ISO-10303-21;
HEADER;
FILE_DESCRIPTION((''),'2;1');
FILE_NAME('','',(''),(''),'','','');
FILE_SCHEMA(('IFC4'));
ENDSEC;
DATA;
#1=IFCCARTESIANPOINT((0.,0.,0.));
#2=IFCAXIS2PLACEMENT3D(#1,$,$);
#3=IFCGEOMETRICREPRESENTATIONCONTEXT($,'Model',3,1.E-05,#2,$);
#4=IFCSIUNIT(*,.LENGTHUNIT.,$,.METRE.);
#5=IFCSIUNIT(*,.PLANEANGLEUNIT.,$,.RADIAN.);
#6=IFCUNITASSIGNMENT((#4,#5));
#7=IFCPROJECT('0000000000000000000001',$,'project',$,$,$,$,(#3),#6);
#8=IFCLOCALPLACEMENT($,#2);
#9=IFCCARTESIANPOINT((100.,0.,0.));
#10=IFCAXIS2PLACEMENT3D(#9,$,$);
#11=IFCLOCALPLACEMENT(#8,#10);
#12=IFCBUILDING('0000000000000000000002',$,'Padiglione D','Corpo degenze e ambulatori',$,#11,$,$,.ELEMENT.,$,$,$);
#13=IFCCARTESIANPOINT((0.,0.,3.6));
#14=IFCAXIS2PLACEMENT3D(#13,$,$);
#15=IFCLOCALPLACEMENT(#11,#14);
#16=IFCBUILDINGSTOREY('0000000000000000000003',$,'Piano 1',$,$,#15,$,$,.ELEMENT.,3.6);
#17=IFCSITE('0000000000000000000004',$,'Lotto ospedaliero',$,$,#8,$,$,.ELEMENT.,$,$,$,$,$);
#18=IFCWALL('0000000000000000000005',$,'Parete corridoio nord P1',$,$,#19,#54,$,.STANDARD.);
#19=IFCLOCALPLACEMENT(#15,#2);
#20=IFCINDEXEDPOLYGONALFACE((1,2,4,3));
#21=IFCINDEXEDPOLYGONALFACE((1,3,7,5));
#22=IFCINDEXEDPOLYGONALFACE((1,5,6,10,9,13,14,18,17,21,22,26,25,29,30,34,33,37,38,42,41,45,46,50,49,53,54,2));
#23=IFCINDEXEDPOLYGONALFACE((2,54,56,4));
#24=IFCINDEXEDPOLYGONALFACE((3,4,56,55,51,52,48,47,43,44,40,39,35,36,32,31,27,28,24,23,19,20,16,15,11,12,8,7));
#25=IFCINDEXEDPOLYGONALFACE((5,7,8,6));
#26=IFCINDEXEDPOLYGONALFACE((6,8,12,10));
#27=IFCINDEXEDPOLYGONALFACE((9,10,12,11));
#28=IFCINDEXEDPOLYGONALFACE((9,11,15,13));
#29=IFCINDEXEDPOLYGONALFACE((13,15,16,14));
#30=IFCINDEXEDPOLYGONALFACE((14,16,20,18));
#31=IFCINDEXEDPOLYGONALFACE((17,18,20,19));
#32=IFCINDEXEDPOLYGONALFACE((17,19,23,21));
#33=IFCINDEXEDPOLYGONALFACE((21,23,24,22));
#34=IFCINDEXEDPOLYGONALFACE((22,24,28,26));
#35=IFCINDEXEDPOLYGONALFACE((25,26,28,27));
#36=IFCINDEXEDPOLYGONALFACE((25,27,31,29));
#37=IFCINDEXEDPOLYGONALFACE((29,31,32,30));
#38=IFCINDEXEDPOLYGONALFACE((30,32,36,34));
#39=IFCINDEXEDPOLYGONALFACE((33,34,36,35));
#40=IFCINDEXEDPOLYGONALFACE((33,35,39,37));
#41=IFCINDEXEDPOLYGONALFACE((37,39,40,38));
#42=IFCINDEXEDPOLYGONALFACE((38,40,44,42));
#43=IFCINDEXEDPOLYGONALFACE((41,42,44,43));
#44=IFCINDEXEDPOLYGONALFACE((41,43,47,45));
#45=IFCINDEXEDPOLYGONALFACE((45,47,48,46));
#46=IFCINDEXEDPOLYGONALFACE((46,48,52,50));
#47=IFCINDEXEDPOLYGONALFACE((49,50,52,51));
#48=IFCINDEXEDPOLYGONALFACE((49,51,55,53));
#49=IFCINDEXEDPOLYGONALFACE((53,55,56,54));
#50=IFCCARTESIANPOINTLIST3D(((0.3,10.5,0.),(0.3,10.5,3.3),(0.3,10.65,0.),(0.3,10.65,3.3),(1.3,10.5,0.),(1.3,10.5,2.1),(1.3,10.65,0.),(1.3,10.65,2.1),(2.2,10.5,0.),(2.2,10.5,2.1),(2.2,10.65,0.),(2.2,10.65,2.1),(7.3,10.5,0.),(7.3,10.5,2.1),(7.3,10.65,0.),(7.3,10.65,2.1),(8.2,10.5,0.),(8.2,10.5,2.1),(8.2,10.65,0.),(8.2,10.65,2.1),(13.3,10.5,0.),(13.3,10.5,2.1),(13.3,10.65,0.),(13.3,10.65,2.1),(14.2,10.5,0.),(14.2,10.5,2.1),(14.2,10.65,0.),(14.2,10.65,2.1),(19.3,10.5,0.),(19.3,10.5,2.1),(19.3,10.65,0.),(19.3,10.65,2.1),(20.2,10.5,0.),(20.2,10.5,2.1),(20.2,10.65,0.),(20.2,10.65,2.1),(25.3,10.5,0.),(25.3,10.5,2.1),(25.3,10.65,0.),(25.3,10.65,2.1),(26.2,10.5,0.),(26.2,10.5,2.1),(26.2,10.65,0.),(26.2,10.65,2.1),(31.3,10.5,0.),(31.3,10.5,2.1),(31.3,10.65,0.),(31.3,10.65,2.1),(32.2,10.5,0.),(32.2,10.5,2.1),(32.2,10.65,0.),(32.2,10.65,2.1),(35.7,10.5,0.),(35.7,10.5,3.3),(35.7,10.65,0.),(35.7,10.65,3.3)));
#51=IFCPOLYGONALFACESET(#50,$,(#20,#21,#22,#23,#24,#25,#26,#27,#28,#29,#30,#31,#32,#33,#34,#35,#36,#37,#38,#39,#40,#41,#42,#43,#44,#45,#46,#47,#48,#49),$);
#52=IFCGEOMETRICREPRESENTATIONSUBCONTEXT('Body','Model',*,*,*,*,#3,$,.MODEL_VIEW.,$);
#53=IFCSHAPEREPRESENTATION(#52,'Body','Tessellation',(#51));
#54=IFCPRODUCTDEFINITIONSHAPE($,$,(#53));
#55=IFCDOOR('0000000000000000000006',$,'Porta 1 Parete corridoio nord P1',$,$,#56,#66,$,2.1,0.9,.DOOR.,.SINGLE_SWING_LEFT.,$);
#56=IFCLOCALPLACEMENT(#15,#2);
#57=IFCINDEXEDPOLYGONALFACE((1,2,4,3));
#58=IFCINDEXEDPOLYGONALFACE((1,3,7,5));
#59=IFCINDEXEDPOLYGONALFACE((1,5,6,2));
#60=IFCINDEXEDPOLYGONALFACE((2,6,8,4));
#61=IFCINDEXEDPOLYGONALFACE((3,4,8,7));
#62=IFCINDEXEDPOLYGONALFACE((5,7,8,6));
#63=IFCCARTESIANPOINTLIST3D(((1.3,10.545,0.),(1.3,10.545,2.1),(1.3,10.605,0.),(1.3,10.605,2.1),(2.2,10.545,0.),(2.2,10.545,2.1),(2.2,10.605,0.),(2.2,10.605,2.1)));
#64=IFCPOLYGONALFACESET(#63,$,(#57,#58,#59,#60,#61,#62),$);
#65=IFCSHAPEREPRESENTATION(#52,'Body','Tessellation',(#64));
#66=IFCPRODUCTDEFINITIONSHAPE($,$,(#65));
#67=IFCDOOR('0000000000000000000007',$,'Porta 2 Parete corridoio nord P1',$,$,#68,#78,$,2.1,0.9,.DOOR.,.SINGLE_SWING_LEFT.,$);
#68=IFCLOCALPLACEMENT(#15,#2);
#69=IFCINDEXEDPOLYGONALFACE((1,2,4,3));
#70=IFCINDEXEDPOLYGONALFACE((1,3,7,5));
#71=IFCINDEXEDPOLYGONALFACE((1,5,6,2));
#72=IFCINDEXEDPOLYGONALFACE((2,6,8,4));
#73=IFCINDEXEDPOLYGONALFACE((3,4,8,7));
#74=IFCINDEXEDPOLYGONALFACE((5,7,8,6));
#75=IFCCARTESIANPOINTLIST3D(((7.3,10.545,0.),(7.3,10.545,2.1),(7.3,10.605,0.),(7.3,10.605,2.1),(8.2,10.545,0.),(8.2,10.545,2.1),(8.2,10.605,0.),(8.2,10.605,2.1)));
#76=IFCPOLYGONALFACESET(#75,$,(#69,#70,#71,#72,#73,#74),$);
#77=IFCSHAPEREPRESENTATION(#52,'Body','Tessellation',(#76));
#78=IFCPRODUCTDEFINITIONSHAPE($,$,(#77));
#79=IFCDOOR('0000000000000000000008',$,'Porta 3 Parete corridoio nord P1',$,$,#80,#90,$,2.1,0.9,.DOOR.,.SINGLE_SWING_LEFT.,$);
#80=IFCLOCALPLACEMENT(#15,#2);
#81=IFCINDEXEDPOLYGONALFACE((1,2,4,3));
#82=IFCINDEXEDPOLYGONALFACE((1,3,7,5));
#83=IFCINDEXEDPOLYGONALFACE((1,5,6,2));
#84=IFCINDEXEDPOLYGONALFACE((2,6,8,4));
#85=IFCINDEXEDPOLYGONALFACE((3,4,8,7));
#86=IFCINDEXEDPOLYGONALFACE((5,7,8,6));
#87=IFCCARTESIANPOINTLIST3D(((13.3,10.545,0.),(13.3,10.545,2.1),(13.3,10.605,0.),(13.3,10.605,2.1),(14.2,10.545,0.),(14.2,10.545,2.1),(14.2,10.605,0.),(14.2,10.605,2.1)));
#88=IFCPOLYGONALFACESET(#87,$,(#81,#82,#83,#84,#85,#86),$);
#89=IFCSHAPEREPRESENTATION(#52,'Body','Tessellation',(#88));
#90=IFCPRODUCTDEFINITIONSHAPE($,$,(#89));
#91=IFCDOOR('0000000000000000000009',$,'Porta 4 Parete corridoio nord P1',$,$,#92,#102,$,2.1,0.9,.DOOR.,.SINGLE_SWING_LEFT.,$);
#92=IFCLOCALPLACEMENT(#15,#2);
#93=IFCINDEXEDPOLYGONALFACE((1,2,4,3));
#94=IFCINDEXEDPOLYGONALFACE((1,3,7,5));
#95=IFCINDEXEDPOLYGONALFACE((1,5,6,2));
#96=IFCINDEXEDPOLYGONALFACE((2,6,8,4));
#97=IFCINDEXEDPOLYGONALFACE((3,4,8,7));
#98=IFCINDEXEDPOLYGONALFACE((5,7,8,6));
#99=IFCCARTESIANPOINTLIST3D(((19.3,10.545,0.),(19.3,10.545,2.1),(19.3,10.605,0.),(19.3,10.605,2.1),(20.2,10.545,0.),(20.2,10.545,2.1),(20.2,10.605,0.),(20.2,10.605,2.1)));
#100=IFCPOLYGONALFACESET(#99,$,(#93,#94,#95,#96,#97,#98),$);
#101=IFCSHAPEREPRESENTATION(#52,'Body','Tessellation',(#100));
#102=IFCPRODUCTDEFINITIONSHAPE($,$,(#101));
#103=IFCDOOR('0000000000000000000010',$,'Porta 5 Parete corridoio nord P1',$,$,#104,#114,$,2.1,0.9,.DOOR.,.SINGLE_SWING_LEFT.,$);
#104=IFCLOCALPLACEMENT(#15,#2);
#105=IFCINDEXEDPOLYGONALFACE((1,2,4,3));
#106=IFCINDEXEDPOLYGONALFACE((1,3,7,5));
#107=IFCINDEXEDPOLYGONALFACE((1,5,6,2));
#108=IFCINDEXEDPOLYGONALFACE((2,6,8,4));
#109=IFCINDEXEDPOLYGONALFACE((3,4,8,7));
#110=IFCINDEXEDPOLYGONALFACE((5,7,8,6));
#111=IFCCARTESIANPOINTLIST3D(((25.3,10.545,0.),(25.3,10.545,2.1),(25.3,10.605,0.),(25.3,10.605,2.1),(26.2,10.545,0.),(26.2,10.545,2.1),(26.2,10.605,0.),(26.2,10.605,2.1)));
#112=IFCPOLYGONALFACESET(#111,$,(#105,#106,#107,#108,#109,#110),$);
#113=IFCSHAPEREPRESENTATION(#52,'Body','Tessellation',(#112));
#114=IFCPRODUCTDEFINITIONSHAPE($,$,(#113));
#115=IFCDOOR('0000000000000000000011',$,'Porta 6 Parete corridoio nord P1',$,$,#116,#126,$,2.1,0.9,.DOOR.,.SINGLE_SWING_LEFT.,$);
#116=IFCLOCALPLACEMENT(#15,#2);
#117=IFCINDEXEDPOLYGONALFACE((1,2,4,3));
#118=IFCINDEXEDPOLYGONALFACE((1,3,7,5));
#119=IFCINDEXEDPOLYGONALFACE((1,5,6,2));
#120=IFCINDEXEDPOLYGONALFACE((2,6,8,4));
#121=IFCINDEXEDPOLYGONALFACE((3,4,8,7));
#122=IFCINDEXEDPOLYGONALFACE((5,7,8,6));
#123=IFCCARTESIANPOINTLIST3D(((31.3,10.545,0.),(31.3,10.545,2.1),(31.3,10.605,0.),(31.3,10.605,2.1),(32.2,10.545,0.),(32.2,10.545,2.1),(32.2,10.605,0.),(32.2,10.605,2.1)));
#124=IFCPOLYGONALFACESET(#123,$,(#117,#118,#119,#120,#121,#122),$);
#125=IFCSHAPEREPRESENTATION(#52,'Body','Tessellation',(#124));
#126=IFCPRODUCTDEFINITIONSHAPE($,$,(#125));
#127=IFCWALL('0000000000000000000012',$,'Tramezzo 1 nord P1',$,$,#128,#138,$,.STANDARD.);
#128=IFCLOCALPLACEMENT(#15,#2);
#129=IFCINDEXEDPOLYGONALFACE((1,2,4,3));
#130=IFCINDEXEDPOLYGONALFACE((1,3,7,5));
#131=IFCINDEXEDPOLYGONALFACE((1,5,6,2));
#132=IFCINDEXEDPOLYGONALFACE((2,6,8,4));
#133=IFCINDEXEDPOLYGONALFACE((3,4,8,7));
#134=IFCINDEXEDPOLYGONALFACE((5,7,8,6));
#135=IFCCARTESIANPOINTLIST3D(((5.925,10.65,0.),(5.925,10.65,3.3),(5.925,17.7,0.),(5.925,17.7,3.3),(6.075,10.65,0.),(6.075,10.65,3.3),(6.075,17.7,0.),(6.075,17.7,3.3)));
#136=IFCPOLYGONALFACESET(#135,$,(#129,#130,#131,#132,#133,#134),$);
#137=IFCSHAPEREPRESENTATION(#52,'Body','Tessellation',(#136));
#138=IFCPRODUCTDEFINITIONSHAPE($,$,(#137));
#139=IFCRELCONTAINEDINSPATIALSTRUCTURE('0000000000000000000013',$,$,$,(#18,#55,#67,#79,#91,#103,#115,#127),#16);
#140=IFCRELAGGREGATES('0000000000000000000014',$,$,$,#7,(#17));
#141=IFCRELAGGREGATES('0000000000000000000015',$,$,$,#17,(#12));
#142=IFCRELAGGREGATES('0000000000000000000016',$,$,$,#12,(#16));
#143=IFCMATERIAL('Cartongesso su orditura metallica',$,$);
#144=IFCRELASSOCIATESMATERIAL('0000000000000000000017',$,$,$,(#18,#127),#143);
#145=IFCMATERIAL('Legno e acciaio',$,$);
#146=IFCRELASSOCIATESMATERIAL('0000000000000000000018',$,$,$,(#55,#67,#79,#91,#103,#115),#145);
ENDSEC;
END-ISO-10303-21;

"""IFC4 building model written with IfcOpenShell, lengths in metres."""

from ifc_helpers import new_model, si_unit, frame, frame_2d, origin, place, context, subcontext, project, spatial, rectangle, extrude, material, element, fill, save


model = new_model("IFC4")

# Units and contexts
model_context = context("Model", 3, precision=1e-05, world=origin())
body_context = subcontext(model_context, "Body", "Model", "MODEL_VIEW")
ifc_project = project(units=[si_unit("LENGTHUNIT", "METRE"), si_unit("PLANEANGLEUNIT", "RADIAN")], contexts=[model_context])

# Site, building, storey
site_placement = place(None, origin())
site = spatial("IfcSite", under=ifc_project, at=site_placement, Name="Lotto ospedaliero", CompositionType="ELEMENT")
building_placement = place(site_placement, frame((100.0, 0.0, 0.0)))
building = spatial("IfcBuilding", under=site, at=building_placement, Name="Padiglione D", Description="Corpo degenze e ambulatori", CompositionType="ELEMENT")
storey_placement = place(building_placement, frame((0.0, 0.0, 3.6)))
storey = spatial("IfcBuildingStorey", under=building, at=storey_placement, Name="Piano 1", CompositionType="ELEMENT", Elevation=3.6)

# Wall, openings, doors
ifc_material_1 = material(Name="Cartongesso su orditura metallica")
ifc_material_2 = material(Name="Legno e acciaio")
wall_1_placement = place(storey_placement, frame((0.3, 10.5, 0.0)))
wall_1 = element("IfcWall", 1, at=wall_1_placement, inside=storey, material=ifc_material_1, Name="Parete corridoio nord P1", PredefinedType="STANDARD", context=body_context, shape_type="SweptSolid", body=[
    extrude(rectangle(XDim=35.4, YDim=0.15, at=frame_2d((17.7, 0.075))), origin(), (0.0, 0.0, 1.0), 3.3),
])
opening_1_placement = place(wall_1_placement, frame((1.0, -0.1, 0.0)))
opening_1 = element("IfcOpeningElement", 2, at=opening_1_placement, cuts=wall_1, PredefinedType="OPENING", context=body_context, shape_type="SweptSolid", body=[
    extrude(rectangle(XDim=0.9, YDim=0.35, at=frame_2d((0.45, 0.175))), origin(), (0.0, 0.0, 1.0), 2.1),
])
opening_2_placement = place(wall_1_placement, frame((7.0, -0.1, 0.0)))
opening_2 = element("IfcOpeningElement", 3, at=opening_2_placement, cuts=wall_1, PredefinedType="OPENING", context=body_context, shape_type="SweptSolid", body=[
    extrude(rectangle(XDim=0.9, YDim=0.35, at=frame_2d((0.45, 0.175))), origin(), (0.0, 0.0, 1.0), 2.1),
])
opening_3_placement = place(wall_1_placement, frame((13.0, -0.1, 0.0)))
opening_3 = element("IfcOpeningElement", 4, at=opening_3_placement, cuts=wall_1, PredefinedType="OPENING", context=body_context, shape_type="SweptSolid", body=[
    extrude(rectangle(XDim=0.9, YDim=0.35, at=frame_2d((0.45, 0.175))), origin(), (0.0, 0.0, 1.0), 2.1),
])
opening_4_placement = place(wall_1_placement, frame((19.0, -0.1, 0.0)))
opening_4 = element("IfcOpeningElement", 5, at=opening_4_placement, cuts=wall_1, PredefinedType="OPENING", context=body_context, shape_type="SweptSolid", body=[
    extrude(rectangle(XDim=0.9, YDim=0.35, at=frame_2d((0.45, 0.175))), origin(), (0.0, 0.0, 1.0), 2.1),
])
opening_5_placement = place(wall_1_placement, frame((25.0, -0.1, 0.0)))
opening_5 = element("IfcOpeningElement", 6, at=opening_5_placement, cuts=wall_1, PredefinedType="OPENING", context=body_context, shape_type="SweptSolid", body=[
    extrude(rectangle(XDim=0.9, YDim=0.35, at=frame_2d((0.45, 0.175))), origin(), (0.0, 0.0, 1.0), 2.1),
])
opening_6_placement = place(wall_1_placement, frame((31.0, -0.1, 0.0)))
opening_6 = element("IfcOpeningElement", 7, at=opening_6_placement, cuts=wall_1, PredefinedType="OPENING", context=body_context, shape_type="SweptSolid", body=[
    extrude(rectangle(XDim=0.9, YDim=0.35, at=frame_2d((0.45, 0.175))), origin(), (0.0, 0.0, 1.0), 2.1),
])
door_1_placement = place(wall_1_placement, frame((1.0, 0.045, 0.0)))
door_1 = element("IfcDoor", 8, at=door_1_placement, inside=storey, material=ifc_material_2, Name="Porta 1 Parete corridoio nord P1", OperationType="SINGLE_SWING_LEFT", OverallHeight=2.1, OverallWidth=0.9, PredefinedType="DOOR", context=body_context, shape_type="SweptSolid", body=[
    extrude(rectangle(XDim=0.9, YDim=0.06, at=frame_2d((0.45, 0.03))), origin(), (0.0, 0.0, 1.0), 2.1),
])
fill(opening_1, door_1)
door_2_placement = place(wall_1_placement, frame((7.0, 0.045, 0.0)))
door_2 = element("IfcDoor", 9, at=door_2_placement, inside=storey, material=ifc_material_2, Name="Porta 2 Parete corridoio nord P1", OperationType="SINGLE_SWING_LEFT", OverallHeight=2.1, OverallWidth=0.9, PredefinedType="DOOR", context=body_context, shape_type="SweptSolid", body=[
    extrude(rectangle(XDim=0.9, YDim=0.06, at=frame_2d((0.45, 0.03))), origin(), (0.0, 0.0, 1.0), 2.1),
])
fill(opening_2, door_2)
door_3_placement = place(wall_1_placement, frame((13.0, 0.045, 0.0)))
door_3 = element("IfcDoor", 10, at=door_3_placement, inside=storey, material=ifc_material_2, Name="Porta 3 Parete corridoio nord P1", OperationType="SINGLE_SWING_LEFT", OverallHeight=2.1, OverallWidth=0.9, PredefinedType="DOOR", context=body_context, shape_type="SweptSolid", body=[
    extrude(rectangle(XDim=0.9, YDim=0.06, at=frame_2d((0.45, 0.03))), origin(), (0.0, 0.0, 1.0), 2.1),
])
fill(opening_3, door_3)
door_4_placement = place(wall_1_placement, frame((19.0, 0.045, 0.0)))
door_4 = element("IfcDoor", 11, at=door_4_placement, inside=storey, material=ifc_material_2, Name="Porta 4 Parete corridoio nord P1", OperationType="SINGLE_SWING_LEFT", OverallHeight=2.1, OverallWidth=0.9, PredefinedType="DOOR", context=body_context, shape_type="SweptSolid", body=[
    extrude(rectangle(XDim=0.9, YDim=0.06, at=frame_2d((0.45, 0.03))), origin(), (0.0, 0.0, 1.0), 2.1),
])
fill(opening_4, door_4)
door_5_placement = place(wall_1_placement, frame((25.0, 0.045, 0.0)))
door_5 = element("IfcDoor", 12, at=door_5_placement, inside=storey, material=ifc_material_2, Name="Porta 5 Parete corridoio nord P1", OperationType="SINGLE_SWING_LEFT", OverallHeight=2.1, OverallWidth=0.9, PredefinedType="DOOR", context=body_context, shape_type="SweptSolid", body=[
    extrude(rectangle(XDim=0.9, YDim=0.06, at=frame_2d((0.45, 0.03))), origin(), (0.0, 0.0, 1.0), 2.1),
])
fill(opening_5, door_5)
door_6_placement = place(wall_1_placement, frame((31.0, 0.045, 0.0)))
door_6 = element("IfcDoor", 13, at=door_6_placement, inside=storey, material=ifc_material_2, Name="Porta 6 Parete corridoio nord P1", OperationType="SINGLE_SWING_LEFT", OverallHeight=2.1, OverallWidth=0.9, PredefinedType="DOOR", context=body_context, shape_type="SweptSolid", body=[
    extrude(rectangle(XDim=0.9, YDim=0.06, at=frame_2d((0.45, 0.03))), origin(), (0.0, 0.0, 1.0), 2.1),
])
fill(opening_6, door_6)

# Wall
wall_2_placement = place(storey_placement, frame((5.925, 10.65, 0.0)))
element("IfcWall", 14, at=wall_2_placement, inside=storey, material=ifc_material_1, Name="Tramezzo 1 nord P1", PredefinedType="STANDARD", context=body_context, shape_type="SweptSolid", body=[
    extrude(rectangle(XDim=0.15, YDim=7.05, at=frame_2d((0.075, 3.525))), origin(), (0.0, 0.0, 1.0), 3.3),
])

save(model, "model.ifc")
